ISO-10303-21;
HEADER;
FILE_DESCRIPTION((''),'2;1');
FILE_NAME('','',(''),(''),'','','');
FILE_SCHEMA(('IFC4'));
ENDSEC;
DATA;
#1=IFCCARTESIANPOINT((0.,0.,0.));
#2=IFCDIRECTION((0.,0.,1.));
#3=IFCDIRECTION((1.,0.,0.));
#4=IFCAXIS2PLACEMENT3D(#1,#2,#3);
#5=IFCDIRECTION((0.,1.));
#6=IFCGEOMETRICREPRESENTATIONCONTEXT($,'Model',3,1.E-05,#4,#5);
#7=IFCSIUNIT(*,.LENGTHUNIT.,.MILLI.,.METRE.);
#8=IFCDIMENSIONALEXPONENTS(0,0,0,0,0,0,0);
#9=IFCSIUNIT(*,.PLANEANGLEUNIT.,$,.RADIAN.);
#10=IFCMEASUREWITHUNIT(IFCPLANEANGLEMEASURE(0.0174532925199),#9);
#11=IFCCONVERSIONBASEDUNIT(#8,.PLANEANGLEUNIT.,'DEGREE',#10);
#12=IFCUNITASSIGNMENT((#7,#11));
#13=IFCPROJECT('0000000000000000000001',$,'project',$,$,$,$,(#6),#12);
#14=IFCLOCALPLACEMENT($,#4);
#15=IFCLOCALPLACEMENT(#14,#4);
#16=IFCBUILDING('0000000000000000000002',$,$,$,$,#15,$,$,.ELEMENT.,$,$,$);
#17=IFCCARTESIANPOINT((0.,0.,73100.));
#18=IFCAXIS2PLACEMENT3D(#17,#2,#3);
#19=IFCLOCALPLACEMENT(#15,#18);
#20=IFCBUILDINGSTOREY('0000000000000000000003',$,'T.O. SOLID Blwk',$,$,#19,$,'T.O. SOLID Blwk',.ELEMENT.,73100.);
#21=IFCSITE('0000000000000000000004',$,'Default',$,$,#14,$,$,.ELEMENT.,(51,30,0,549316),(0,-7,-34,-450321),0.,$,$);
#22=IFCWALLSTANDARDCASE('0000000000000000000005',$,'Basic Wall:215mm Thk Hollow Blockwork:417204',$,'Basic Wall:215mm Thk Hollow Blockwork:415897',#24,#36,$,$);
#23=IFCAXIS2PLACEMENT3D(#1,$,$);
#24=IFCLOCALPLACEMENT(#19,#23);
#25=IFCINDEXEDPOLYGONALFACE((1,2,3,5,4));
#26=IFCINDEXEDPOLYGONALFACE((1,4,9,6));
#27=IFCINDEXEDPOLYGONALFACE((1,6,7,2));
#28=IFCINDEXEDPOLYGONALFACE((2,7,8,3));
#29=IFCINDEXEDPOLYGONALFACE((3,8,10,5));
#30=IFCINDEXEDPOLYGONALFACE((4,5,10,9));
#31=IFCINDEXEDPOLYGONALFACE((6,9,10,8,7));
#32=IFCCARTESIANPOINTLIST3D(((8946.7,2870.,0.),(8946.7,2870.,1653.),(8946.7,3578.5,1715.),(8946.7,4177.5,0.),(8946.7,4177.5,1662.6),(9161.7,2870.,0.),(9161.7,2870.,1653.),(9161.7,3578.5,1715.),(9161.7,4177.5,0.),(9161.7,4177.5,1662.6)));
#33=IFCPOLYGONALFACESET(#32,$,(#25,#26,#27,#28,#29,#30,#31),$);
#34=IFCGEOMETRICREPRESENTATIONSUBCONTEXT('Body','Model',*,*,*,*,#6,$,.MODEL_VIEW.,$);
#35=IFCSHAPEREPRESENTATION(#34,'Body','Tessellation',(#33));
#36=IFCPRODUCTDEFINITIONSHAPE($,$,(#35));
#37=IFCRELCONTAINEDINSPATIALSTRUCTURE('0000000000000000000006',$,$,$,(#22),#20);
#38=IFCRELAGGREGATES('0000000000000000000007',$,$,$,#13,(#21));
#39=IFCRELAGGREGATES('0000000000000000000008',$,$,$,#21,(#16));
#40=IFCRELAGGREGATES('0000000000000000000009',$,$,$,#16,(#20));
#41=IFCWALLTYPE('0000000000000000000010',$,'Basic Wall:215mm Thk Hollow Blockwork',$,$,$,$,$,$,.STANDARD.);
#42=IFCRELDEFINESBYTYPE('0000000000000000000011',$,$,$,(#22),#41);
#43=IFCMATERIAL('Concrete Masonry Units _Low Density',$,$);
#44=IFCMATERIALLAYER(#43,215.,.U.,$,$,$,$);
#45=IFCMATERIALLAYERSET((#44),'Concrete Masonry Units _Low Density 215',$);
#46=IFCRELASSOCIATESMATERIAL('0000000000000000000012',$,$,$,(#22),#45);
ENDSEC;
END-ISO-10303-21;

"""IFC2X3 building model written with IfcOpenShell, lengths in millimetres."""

from ifc_helpers import new_model, entity, si_unit, converted_unit, direction, frame, origin_with_axes, place, context, subcontext, project, spatial, polyline, outline, extrude, clip, halfspace, material, layer, layer_set, layer_usage, type_object, element, save


model = new_model("IFC2X3")

# Units and contexts
model_context = context("Model", 3, precision=1e-05, world=origin_with_axes(), true_north=direction((0.0, 1.0)))
body_context = subcontext(model_context, "Body", "Model", "MODEL_VIEW")
ifc_project = project(units=[si_unit("LENGTHUNIT", "METRE", prefix="MILLI"), converted_unit("PLANEANGLEUNIT", "DEGREE", entity("IfcPlaneAngleMeasure", 0.0174532925199), si_unit("PLANEANGLEUNIT", "RADIAN"), dimensions=[0, 0, 0, 0, 0, 0, 0])], contexts=[model_context])

# Site, building, storey
site_placement = place(None, origin_with_axes())
site = spatial("IfcSite", under=ifc_project, at=site_placement, Name="Default", CompositionType="ELEMENT", RefLatitude=(51, 30, 0, 549316), RefLongitude=(0, -7, -34, -450321), RefElevation=0.0)
building_placement = place(site_placement, origin_with_axes())
building = spatial("IfcBuilding", under=site, at=building_placement, CompositionType="ELEMENT")
storey_placement = place(building_placement, frame((0.0, 0.0, 73100.0), z_axis=(0.0, 0.0, 1.0), x_axis=(1.0, 0.0, 0.0)))
storey = spatial("IfcBuildingStorey", under=building, at=storey_placement, Name="T.O. SOLID Blwk", LongName="T.O. SOLID Blwk", CompositionType="ELEMENT", Elevation=73100.0)

# Shared definitions
ifc_material_1 = material(Name="Concrete Masonry Units _Low Density")
ifc_layer = layer(ifc_material_1, 215.0, ventilated="UNKNOWN")
ifc_layer_set = layer_set([ifc_layer], Name="Concrete Masonry Units _Low Density 215")
wall_type = type_object("IfcWallType", Name="Basic Wall:215mm Thk Hollow Blockwork", PredefinedType="STANDARD")

# Wall
ifc_layer_usage_1 = layer_usage(ifc_layer_set, "AXIS2", "POSITIVE", -107.5)
wall_1_placement = place(storey_placement, frame((9054.2, 2870.0, 0.0), z_axis=(0.0, 0.0, 1.0), x_axis=(0.0, 1.0, 0.0)))
element("IfcWallStandardCase", 1, at=wall_1_placement, inside=storey, type_object=wall_type, material=ifc_layer_usage_1, Name="Basic Wall:215mm Thk Hollow Blockwork:417204", ObjectType="Basic Wall:215mm Thk Hollow Blockwork:415897", context=body_context, shape_type="Clipping", body=[
    clip(clip(extrude(outline(polyline([(0.0, -107.5), (1307.5, -107.5), (1307.5, 107.5), (0.0, 107.5), (0.0, -107.5)])), origin_with_axes(), (0.0, 0.0, 1.0), 1715.0), halfspace(frame((154.3, 0.0, 1763.5), z_axis=(-0.087156, 0.0, -0.996195), x_axis=(0.0, 1.0, 0.0)), True)), halfspace(frame((-143.5, 0.0, 1640.5), z_axis=(0.087156, 0.0, -0.996195), x_axis=(0.0, 1.0, 0.0)), True)),
])

save(model, "model.ifc")
